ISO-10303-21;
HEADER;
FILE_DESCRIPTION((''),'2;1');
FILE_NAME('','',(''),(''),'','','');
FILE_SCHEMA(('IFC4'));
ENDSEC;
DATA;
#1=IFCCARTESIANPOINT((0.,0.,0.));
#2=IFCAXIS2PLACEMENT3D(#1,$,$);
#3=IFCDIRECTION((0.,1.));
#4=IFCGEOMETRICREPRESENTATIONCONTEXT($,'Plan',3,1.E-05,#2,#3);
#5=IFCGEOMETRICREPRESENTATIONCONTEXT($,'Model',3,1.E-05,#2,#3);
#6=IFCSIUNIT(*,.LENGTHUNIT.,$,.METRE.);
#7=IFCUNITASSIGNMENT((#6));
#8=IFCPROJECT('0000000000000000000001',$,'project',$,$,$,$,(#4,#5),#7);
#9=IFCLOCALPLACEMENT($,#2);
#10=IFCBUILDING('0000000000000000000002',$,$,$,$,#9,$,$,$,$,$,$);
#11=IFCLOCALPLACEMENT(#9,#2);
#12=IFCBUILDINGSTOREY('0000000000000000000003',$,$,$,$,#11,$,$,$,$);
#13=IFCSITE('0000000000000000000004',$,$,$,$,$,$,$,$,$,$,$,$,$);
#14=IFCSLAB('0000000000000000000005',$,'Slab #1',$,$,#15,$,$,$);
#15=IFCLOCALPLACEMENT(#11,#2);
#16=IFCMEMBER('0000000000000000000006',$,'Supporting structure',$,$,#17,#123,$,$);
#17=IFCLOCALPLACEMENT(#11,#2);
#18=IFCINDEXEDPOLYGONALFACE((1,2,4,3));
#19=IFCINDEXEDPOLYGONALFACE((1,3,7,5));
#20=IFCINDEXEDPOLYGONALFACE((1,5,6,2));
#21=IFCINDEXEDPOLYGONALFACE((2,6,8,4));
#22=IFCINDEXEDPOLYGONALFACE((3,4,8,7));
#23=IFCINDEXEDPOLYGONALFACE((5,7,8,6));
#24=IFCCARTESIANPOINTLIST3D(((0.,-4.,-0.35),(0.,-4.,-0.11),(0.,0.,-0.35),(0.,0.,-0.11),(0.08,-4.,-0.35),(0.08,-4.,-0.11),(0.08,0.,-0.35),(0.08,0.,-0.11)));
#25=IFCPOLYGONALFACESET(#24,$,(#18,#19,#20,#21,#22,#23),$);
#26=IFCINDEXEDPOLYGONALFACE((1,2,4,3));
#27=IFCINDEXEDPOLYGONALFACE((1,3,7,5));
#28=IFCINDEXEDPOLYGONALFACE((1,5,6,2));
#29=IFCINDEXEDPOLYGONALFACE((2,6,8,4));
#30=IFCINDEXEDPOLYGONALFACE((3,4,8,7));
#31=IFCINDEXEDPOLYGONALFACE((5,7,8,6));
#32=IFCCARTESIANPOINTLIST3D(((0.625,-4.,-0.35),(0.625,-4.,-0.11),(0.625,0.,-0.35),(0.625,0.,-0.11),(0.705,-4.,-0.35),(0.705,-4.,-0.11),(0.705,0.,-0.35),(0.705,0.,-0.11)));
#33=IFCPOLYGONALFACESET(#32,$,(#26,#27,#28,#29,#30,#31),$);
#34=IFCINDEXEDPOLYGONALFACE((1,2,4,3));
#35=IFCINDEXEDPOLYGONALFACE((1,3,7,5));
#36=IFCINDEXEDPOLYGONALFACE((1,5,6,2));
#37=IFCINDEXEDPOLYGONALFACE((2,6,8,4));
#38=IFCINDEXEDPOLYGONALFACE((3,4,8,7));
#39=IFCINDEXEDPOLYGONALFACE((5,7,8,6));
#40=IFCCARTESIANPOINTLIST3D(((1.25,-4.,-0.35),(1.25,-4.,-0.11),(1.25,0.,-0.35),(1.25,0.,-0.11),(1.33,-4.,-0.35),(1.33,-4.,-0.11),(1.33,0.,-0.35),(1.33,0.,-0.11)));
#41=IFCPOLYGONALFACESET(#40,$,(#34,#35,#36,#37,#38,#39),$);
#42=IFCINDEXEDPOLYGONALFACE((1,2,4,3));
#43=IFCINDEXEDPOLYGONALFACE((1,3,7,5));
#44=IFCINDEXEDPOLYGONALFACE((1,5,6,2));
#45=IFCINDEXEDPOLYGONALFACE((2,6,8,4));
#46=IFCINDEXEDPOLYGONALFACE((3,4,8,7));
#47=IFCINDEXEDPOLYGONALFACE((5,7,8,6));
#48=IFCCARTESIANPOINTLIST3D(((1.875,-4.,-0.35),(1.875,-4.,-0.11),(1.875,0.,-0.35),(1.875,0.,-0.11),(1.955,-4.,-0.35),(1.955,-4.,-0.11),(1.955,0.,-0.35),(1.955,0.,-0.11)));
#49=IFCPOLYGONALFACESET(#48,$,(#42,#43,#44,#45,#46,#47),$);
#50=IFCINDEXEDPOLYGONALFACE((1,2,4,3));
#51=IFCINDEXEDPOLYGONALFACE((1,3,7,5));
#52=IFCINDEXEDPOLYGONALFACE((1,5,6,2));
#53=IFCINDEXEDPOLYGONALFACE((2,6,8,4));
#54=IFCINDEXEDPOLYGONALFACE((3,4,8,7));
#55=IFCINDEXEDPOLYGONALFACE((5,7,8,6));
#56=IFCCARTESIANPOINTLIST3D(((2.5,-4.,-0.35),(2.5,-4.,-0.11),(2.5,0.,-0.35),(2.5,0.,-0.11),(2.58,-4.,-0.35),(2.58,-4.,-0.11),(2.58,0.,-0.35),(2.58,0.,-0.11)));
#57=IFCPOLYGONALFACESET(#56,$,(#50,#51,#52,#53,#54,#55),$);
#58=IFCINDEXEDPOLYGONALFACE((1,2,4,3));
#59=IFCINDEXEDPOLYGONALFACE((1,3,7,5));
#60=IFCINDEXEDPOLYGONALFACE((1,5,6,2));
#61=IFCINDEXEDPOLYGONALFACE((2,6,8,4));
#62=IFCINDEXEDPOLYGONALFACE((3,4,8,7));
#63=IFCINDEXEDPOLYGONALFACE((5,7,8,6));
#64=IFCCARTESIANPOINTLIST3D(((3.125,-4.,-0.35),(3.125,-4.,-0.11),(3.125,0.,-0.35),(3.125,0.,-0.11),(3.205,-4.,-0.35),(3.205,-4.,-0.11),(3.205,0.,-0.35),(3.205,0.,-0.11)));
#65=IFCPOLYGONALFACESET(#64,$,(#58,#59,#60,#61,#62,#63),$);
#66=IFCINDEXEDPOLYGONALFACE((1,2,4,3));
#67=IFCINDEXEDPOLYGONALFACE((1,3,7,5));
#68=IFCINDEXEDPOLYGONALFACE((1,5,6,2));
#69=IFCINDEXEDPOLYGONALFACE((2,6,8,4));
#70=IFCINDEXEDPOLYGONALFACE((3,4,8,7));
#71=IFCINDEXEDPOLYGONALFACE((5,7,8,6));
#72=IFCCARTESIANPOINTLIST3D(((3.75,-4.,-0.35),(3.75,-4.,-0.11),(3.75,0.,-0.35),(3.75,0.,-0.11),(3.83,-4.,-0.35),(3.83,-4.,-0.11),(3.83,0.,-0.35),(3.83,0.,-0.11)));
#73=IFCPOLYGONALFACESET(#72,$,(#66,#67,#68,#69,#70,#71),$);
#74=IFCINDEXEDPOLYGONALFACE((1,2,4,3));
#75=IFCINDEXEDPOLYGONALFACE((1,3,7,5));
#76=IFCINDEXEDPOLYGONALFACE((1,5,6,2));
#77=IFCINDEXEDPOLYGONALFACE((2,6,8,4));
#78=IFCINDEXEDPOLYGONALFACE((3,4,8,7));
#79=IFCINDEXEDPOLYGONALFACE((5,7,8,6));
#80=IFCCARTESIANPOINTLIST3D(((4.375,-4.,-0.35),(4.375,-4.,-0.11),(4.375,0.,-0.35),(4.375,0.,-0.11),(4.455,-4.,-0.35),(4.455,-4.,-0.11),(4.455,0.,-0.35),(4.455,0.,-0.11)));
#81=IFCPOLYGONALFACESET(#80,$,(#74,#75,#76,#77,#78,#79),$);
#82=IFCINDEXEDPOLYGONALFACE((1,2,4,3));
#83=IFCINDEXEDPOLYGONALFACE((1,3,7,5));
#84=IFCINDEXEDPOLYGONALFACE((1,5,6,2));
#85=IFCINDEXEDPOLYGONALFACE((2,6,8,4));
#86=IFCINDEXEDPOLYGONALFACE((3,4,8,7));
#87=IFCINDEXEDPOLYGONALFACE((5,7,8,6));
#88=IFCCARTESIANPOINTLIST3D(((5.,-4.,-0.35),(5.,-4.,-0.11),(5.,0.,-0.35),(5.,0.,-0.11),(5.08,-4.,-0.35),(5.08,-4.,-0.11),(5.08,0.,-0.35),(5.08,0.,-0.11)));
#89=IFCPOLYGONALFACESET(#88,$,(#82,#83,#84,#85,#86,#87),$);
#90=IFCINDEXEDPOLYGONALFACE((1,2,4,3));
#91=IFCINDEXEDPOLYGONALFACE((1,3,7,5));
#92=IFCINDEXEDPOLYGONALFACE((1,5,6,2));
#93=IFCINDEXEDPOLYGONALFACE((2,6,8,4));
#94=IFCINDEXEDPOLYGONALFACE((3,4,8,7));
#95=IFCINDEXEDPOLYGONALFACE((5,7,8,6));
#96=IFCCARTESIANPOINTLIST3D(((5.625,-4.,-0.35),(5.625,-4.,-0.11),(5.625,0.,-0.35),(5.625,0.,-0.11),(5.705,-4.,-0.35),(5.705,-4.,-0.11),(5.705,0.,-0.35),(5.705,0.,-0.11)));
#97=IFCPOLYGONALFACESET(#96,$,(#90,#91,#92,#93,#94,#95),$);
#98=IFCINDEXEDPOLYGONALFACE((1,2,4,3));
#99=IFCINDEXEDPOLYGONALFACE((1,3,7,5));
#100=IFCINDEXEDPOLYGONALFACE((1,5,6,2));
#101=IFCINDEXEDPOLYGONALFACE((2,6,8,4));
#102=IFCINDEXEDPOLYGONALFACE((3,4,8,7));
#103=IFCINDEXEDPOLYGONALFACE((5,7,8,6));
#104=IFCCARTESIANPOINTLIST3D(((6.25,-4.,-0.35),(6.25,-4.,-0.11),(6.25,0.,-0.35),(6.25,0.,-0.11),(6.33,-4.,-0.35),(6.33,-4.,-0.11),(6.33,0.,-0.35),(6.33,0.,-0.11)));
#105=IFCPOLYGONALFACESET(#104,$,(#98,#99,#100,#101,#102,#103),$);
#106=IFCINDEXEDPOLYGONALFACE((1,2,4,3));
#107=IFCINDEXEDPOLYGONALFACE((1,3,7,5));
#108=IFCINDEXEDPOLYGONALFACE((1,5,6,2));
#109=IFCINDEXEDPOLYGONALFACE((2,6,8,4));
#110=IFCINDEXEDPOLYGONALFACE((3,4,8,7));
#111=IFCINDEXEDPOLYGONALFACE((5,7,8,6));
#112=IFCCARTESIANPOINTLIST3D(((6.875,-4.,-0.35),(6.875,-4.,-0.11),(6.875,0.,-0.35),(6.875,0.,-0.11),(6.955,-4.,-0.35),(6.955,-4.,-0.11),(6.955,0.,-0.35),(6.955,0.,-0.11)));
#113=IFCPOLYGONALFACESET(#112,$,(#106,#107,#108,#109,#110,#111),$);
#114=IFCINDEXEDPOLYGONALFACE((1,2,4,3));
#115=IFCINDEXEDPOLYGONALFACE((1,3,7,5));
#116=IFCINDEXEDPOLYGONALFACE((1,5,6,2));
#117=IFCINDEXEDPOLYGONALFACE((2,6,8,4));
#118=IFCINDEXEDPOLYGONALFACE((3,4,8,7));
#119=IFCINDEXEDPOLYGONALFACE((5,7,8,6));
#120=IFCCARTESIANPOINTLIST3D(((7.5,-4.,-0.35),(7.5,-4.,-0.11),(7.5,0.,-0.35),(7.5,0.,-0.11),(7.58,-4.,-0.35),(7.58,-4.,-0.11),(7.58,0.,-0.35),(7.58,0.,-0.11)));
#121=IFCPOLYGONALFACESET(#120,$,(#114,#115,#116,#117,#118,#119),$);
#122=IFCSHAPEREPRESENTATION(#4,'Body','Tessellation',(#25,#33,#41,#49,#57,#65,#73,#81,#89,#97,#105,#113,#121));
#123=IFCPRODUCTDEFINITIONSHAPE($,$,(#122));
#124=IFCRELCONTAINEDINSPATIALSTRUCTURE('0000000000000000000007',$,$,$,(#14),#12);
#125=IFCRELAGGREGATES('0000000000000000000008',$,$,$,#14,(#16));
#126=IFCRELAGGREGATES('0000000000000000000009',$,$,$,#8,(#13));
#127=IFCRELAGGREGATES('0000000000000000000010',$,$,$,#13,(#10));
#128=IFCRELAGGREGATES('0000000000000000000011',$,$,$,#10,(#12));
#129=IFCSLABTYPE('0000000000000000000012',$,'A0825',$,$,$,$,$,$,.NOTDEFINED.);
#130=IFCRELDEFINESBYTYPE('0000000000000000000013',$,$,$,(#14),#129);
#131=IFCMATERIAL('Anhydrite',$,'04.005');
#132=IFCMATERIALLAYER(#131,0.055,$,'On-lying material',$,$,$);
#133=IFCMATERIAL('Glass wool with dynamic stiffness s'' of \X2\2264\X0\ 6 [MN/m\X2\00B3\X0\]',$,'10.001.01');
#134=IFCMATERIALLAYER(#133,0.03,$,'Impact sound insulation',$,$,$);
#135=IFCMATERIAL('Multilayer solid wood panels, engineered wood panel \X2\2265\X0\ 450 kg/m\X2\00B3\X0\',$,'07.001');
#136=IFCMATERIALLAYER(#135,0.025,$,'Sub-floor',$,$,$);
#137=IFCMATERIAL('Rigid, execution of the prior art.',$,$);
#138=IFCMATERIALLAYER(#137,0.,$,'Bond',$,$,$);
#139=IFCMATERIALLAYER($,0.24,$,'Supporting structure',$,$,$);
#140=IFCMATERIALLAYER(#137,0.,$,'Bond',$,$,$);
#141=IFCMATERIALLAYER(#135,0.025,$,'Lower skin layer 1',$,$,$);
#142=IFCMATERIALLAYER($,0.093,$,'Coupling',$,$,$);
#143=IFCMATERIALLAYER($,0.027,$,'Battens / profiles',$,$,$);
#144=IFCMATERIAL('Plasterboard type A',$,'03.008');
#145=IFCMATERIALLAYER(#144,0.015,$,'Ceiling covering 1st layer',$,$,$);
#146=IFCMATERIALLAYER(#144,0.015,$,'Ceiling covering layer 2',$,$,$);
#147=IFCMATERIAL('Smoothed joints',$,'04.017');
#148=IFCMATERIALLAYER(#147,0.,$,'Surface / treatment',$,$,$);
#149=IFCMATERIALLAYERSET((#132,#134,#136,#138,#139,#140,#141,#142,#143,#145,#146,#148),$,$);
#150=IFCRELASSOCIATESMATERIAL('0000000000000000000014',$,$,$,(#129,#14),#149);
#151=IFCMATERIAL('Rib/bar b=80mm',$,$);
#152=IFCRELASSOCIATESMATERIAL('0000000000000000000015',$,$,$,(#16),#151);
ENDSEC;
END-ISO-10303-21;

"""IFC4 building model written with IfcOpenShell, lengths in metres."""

from ifc_helpers import new_model, si_unit, direction, frame, frame_2d, origin, place, context, project, spatial, rectangle, extrude, material, layer, layer_set, type_object, element, aggregate, save


model = new_model("IFC4")

# Units and contexts
plan_context = context("Plan", 3, precision=1e-05, world=origin(), true_north=direction((0.0, 1.0)))
model_context = context("Model", 3, precision=1e-05, world=origin(), true_north=direction((0.0, 1.0)))
ifc_project = project(units=[si_unit("LENGTHUNIT", "METRE")], contexts=[plan_context, model_context])

# Site, building, storey
site = spatial("IfcSite", under=ifc_project)
building_placement = place(None, origin())
building = spatial("IfcBuilding", under=site, at=building_placement)
storey_placement = place(building_placement, origin())
storey = spatial("IfcBuildingStorey", under=building, at=storey_placement)

# Slab, member
ifc_material_1 = material(Name="Anhydrite", Category="04.005")
ifc_layer_1 = layer(ifc_material_1, 0.055, Name="On-lying material")
ifc_material_2 = material(Name="Glass wool with dynamic stiffness s' of ≤ 6 [MN/m³]", Category="10.001.01")
ifc_layer_2 = layer(ifc_material_2, 0.03, Name="Impact sound insulation")
ifc_material_3 = material(Name="Multilayer solid wood panels, engineered wood panel ≥ 450 kg/m³", Category="07.001")
ifc_layer_3 = layer(ifc_material_3, 0.025, Name="Sub-floor")
ifc_material_4 = material(Name="Rigid, execution of the prior art.")
ifc_layer_4 = layer(ifc_material_4, 0.0, Name="Bond")
ifc_layer_5 = layer(None, 0.24, Name="Supporting structure")
ifc_layer_6 = layer(ifc_material_4, 0.0, Name="Bond")
ifc_layer_7 = layer(ifc_material_3, 0.025, Name="Lower skin layer 1")
ifc_layer_8 = layer(None, 0.093, Name="Coupling")
ifc_layer_9 = layer(None, 0.027, Name="Battens / profiles")
ifc_material_5 = material(Name="Plasterboard type A", Category="03.008")
ifc_layer_10 = layer(ifc_material_5, 0.015, Name="Ceiling covering 1st layer")
ifc_layer_11 = layer(ifc_material_5, 0.015, Name="Ceiling covering layer 2")
ifc_material_6 = material(Name="Smoothed joints", Category="04.017")
ifc_layer_12 = layer(ifc_material_6, 0.0, Name="Surface / treatment")
ifc_layer_set = layer_set([ifc_layer_1, ifc_layer_2, ifc_layer_3, ifc_layer_4, ifc_layer_5, ifc_layer_6, ifc_layer_7, ifc_layer_8, ifc_layer_9, ifc_layer_10, ifc_layer_11, ifc_layer_12])
slab_type = type_object("IfcSlabType", Name="A0825", PredefinedType="NOTDEFINED", material=ifc_layer_set)
slab_placement = place(None, frame((0.0, 0.0, 0.0), z_axis=(0.0, 0.0, -1.0), x_axis=(1.0, 0.0, 0.0)))
slab = element("IfcSlab", 1, at=slab_placement, inside=storey, type_object=slab_type, material=ifc_layer_set, Name="Slab #1")
ifc_material_7 = material(Name="Rib/bar b=80mm")
member_1_placement = place(slab_placement, origin())
member_1 = element("IfcMember", 2, at=member_1_placement, material=ifc_material_7, Name="Supporting structure", context=plan_context, shape_type="SweptSolid", body=[
    extrude(rectangle(XDim=0.08, YDim=0.24, at=frame_2d((0.04, 0.12), x_axis=(1.0, 0.0))), frame((0.0, 4.0, 0.11), z_axis=(0.0, -1.0, 0.0), x_axis=(1.0, 0.0, 0.0)), (0.0, 0.0, 1.0), 4.0),
    extrude(rectangle(XDim=0.08, YDim=0.24, at=frame_2d((0.04, 0.12), x_axis=(1.0, 0.0))), frame((0.625, 4.0, 0.11), z_axis=(0.0, -1.0, 0.0), x_axis=(1.0, 0.0, 0.0)), (0.0, 0.0, 1.0), 4.0),
    extrude(rectangle(XDim=0.08, YDim=0.24, at=frame_2d((0.04, 0.12), x_axis=(1.0, 0.0))), frame((1.25, 4.0, 0.11), z_axis=(0.0, -1.0, 0.0), x_axis=(1.0, 0.0, 0.0)), (0.0, 0.0, 1.0), 4.0),
    extrude(rectangle(XDim=0.08, YDim=0.24, at=frame_2d((0.04, 0.12), x_axis=(1.0, 0.0))), frame((1.875, 4.0, 0.11), z_axis=(0.0, -1.0, 0.0), x_axis=(1.0, 0.0, 0.0)), (0.0, 0.0, 1.0), 4.0),
    extrude(rectangle(XDim=0.08, YDim=0.24, at=frame_2d((0.04, 0.12), x_axis=(1.0, 0.0))), frame((2.5, 4.0, 0.11), z_axis=(0.0, -1.0, 0.0), x_axis=(1.0, 0.0, 0.0)), (0.0, 0.0, 1.0), 4.0),
    extrude(rectangle(XDim=0.08, YDim=0.24, at=frame_2d((0.04, 0.12), x_axis=(1.0, 0.0))), frame((3.125, 4.0, 0.11), z_axis=(0.0, -1.0, 0.0), x_axis=(1.0, 0.0, 0.0)), (0.0, 0.0, 1.0), 4.0),
    extrude(rectangle(XDim=0.08, YDim=0.24, at=frame_2d((0.04, 0.12), x_axis=(1.0, 0.0))), frame((3.75, 4.0, 0.11), z_axis=(0.0, -1.0, 0.0), x_axis=(1.0, 0.0, 0.0)), (0.0, 0.0, 1.0), 4.0),
    extrude(rectangle(XDim=0.08, YDim=0.24, at=frame_2d((0.04, 0.12), x_axis=(1.0, 0.0))), frame((4.375, 4.0, 0.11), z_axis=(0.0, -1.0, 0.0), x_axis=(1.0, 0.0, 0.0)), (0.0, 0.0, 1.0), 4.0),
    extrude(rectangle(XDim=0.08, YDim=0.24, at=frame_2d((0.04, 0.12), x_axis=(1.0, 0.0))), frame((5.0, 4.0, 0.11), z_axis=(0.0, -1.0, 0.0), x_axis=(1.0, 0.0, 0.0)), (0.0, 0.0, 1.0), 4.0),
    extrude(rectangle(XDim=0.08, YDim=0.24, at=frame_2d((0.04, 0.12), x_axis=(1.0, 0.0))), frame((5.625, 4.0, 0.11), z_axis=(0.0, -1.0, 0.0), x_axis=(1.0, 0.0, 0.0)), (0.0, 0.0, 1.0), 4.0),
    extrude(rectangle(XDim=0.08, YDim=0.24, at=frame_2d((0.04, 0.12), x_axis=(1.0, 0.0))), frame((6.25, 4.0, 0.11), z_axis=(0.0, -1.0, 0.0), x_axis=(1.0, 0.0, 0.0)), (0.0, 0.0, 1.0), 4.0),
    extrude(rectangle(XDim=0.08, YDim=0.24, at=frame_2d((0.04, 0.12), x_axis=(1.0, 0.0))), frame((6.875, 4.0, 0.11), z_axis=(0.0, -1.0, 0.0), x_axis=(1.0, 0.0, 0.0)), (0.0, 0.0, 1.0), 4.0),
    extrude(rectangle(XDim=0.08, YDim=0.24, at=frame_2d((0.04, 0.12), x_axis=(1.0, 0.0))), frame((7.5, 4.0, 0.11), z_axis=(0.0, -1.0, 0.0), x_axis=(1.0, 0.0, 0.0)), (0.0, 0.0, 1.0), 4.0),
])
aggregate(slab, [member_1])

save(model, "model.ifc")
